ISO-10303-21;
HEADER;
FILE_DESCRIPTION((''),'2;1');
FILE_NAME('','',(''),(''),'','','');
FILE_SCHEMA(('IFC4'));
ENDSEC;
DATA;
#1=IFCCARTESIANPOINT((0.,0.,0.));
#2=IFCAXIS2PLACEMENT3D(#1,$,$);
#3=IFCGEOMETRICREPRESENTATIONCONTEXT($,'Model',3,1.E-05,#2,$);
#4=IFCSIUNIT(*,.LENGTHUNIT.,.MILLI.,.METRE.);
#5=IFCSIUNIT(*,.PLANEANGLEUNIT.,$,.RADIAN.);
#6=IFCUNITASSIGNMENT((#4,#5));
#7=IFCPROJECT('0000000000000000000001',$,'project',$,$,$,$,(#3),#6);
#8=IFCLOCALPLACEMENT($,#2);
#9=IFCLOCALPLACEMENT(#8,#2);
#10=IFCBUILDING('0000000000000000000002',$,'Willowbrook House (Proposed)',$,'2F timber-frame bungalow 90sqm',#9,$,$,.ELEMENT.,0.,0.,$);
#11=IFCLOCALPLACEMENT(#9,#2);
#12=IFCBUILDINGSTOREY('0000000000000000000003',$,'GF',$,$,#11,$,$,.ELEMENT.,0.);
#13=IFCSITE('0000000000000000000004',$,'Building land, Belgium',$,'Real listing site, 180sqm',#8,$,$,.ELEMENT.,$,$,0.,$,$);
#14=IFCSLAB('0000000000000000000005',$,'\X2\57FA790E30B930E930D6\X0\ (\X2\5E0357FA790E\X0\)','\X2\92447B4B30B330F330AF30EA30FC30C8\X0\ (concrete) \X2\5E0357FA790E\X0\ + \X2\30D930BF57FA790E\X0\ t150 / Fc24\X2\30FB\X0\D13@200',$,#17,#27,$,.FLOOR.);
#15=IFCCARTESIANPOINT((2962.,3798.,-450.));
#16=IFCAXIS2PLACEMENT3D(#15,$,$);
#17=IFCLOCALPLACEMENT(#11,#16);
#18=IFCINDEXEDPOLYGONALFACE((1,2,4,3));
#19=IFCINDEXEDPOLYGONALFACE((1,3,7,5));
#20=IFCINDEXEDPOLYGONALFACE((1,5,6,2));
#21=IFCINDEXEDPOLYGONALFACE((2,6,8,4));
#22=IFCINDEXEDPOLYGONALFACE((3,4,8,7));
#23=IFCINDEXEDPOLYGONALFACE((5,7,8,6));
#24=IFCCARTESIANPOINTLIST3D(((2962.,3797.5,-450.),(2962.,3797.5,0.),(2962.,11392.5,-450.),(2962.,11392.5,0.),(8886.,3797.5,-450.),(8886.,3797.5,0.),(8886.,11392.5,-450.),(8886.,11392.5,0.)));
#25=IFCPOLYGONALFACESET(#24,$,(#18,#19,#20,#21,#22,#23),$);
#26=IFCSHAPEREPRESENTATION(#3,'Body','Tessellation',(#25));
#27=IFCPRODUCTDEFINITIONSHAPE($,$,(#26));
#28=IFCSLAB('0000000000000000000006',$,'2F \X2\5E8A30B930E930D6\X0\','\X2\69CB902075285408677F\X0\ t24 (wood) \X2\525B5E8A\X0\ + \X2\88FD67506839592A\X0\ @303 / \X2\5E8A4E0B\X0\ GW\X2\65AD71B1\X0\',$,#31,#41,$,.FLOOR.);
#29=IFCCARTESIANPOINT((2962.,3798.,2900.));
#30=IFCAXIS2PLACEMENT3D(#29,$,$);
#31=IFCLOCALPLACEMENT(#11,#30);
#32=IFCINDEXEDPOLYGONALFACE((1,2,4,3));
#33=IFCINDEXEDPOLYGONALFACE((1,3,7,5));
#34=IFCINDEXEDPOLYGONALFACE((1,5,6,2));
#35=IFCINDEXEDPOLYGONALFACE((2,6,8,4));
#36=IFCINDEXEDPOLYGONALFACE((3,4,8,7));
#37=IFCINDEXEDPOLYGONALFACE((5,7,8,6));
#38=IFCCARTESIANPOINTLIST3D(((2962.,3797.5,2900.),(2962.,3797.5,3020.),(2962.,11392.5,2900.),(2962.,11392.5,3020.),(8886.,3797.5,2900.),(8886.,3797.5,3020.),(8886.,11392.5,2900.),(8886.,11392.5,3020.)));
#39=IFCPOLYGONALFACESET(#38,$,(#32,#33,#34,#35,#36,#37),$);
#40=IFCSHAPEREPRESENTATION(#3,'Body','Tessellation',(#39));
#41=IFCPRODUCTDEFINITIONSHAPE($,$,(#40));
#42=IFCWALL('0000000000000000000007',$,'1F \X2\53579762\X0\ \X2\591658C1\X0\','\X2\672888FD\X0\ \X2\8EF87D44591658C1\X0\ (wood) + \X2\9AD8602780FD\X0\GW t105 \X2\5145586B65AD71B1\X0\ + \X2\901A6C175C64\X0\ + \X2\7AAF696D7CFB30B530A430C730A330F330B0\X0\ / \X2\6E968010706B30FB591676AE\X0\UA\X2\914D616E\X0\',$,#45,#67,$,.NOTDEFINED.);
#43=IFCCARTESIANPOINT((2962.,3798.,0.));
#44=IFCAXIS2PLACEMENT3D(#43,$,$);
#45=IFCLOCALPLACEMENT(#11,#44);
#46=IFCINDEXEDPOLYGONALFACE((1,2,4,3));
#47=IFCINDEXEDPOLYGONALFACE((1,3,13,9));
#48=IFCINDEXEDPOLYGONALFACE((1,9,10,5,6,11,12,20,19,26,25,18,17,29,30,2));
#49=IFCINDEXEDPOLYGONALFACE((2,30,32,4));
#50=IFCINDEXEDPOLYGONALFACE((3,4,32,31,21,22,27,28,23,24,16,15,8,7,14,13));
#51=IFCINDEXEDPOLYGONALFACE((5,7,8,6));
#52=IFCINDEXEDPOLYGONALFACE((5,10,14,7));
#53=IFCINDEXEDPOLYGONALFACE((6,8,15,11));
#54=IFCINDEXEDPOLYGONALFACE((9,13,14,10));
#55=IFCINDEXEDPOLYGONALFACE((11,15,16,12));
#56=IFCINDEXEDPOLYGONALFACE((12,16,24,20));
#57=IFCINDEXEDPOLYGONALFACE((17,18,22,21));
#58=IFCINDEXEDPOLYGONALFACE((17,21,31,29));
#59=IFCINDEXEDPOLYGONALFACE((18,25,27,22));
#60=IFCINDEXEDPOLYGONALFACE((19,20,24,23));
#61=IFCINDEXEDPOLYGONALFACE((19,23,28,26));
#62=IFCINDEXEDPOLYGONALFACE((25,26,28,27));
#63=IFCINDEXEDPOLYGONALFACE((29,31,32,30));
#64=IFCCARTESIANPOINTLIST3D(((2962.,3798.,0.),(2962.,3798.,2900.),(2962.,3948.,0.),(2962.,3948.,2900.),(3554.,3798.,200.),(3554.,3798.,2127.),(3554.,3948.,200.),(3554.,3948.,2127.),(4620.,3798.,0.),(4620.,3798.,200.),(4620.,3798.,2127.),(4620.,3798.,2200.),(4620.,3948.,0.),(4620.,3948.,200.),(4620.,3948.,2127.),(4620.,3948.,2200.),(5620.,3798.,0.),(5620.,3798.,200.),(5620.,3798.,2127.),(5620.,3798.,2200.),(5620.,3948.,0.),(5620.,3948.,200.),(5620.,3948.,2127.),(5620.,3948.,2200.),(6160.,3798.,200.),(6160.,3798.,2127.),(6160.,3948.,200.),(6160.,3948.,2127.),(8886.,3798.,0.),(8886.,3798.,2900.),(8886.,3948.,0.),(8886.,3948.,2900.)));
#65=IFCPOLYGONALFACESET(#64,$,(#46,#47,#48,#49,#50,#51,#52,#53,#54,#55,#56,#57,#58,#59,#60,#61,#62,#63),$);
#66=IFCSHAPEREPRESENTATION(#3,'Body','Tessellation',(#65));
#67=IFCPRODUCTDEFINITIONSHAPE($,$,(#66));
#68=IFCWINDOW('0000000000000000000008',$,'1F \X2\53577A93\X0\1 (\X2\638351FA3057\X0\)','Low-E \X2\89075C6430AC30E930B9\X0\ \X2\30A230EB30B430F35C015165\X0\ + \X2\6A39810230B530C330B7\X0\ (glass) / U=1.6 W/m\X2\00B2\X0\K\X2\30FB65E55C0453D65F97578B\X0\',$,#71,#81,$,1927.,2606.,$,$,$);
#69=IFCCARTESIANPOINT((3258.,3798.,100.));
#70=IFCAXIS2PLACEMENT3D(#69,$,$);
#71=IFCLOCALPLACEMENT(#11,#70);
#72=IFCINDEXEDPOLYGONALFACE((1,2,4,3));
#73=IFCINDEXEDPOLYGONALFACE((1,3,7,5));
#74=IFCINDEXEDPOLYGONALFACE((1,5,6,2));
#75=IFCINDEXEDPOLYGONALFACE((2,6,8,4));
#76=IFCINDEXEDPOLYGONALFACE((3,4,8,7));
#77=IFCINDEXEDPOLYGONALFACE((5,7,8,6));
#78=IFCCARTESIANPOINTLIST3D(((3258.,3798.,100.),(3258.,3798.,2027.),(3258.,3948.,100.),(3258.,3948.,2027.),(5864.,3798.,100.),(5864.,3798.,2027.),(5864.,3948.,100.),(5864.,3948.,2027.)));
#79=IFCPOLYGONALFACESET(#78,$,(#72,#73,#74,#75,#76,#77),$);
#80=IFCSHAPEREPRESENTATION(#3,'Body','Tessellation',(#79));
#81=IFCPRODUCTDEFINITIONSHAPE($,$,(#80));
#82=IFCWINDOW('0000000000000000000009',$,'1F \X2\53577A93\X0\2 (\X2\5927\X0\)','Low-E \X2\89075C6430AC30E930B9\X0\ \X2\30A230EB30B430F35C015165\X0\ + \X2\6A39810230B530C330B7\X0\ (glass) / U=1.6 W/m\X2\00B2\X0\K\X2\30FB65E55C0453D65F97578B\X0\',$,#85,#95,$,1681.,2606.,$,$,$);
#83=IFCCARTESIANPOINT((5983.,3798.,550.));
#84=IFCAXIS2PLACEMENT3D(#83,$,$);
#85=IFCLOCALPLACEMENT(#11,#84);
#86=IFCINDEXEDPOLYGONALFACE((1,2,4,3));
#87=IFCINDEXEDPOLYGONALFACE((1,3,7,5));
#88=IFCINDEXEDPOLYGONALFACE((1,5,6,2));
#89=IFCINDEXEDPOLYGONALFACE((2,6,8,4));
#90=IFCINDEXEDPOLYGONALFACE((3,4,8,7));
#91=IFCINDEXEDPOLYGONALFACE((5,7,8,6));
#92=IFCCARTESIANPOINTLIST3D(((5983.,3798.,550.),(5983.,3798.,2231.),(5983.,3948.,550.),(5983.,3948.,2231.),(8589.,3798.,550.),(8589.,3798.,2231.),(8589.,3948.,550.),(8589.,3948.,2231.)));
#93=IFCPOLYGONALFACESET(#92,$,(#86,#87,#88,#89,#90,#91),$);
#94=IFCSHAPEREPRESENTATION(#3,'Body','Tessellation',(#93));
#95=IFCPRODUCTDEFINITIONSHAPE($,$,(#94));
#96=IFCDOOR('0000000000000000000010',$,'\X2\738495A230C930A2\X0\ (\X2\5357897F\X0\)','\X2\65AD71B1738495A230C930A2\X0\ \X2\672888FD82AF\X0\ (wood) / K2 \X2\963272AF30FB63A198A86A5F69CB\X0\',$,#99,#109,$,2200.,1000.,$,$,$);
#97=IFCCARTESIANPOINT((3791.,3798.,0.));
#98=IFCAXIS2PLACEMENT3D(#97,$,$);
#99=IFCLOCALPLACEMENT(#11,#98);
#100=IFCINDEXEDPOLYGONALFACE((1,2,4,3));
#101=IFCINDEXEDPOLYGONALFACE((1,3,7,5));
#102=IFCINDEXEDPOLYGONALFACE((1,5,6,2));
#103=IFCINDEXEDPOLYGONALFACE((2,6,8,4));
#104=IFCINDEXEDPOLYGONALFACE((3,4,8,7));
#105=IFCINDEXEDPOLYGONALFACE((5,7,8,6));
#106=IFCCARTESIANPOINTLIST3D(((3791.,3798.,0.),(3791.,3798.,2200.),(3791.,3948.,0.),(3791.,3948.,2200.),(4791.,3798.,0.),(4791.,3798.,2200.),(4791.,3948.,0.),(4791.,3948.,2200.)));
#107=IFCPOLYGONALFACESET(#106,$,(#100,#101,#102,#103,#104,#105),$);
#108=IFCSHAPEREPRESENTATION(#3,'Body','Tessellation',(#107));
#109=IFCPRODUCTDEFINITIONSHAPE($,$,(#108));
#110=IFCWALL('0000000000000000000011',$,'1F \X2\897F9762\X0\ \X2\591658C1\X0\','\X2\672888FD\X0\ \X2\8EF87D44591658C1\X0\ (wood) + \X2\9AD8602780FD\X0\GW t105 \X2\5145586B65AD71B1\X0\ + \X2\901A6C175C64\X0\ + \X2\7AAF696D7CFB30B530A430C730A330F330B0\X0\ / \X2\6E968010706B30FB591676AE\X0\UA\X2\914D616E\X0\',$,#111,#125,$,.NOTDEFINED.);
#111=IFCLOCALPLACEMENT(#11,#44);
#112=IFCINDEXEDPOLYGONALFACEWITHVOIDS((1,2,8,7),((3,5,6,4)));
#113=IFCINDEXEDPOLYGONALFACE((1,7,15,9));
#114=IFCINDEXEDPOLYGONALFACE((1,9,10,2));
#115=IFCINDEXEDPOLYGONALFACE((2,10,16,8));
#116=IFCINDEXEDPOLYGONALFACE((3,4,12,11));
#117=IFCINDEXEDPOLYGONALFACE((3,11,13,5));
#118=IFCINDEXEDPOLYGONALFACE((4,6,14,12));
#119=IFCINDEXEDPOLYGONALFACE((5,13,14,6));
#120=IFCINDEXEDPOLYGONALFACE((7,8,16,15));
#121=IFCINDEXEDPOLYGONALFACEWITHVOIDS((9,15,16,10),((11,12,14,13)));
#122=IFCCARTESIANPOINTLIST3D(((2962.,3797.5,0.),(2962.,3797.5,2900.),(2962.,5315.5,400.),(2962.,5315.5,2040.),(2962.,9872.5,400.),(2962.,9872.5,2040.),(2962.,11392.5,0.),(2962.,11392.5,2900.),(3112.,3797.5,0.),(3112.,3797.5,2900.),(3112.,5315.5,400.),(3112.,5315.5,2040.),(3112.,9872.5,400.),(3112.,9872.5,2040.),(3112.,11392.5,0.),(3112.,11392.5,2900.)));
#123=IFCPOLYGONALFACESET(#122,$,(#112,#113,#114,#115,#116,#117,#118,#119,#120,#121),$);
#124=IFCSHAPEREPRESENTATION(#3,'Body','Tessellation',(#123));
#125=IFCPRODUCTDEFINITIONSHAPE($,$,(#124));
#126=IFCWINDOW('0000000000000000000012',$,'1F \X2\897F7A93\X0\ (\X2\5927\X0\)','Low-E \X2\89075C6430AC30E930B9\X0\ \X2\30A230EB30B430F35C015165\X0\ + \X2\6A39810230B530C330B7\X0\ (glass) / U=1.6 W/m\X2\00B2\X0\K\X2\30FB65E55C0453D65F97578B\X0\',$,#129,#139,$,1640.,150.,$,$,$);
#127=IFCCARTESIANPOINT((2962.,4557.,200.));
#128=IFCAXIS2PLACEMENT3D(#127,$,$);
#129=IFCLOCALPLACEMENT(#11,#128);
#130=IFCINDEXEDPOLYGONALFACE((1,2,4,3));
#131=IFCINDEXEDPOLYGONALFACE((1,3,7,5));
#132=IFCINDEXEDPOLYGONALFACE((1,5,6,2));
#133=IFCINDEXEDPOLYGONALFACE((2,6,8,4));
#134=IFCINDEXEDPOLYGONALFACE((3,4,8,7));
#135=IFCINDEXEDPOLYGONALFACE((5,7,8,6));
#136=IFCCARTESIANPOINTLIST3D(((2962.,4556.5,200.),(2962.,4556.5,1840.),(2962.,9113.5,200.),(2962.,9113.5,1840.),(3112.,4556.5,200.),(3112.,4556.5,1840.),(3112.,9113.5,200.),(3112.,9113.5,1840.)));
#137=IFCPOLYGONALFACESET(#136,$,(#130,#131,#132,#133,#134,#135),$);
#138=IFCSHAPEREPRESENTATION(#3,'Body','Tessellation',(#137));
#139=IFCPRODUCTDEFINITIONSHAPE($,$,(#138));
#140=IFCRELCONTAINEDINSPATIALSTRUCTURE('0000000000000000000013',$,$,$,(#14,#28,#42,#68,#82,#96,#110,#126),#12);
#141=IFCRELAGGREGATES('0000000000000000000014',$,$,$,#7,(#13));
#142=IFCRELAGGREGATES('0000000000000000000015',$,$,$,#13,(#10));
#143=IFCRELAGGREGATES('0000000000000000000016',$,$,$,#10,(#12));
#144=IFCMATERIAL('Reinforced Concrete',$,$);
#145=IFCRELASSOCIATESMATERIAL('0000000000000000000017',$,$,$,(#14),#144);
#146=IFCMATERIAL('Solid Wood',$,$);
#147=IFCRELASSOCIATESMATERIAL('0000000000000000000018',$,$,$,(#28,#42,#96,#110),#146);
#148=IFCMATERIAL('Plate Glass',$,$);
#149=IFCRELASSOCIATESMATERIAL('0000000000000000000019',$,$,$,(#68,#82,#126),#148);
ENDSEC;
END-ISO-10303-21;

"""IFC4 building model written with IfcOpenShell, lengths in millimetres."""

from ifc_helpers import new_model, si_unit, frame, frame_2d, origin, place, context, project, spatial, rectangle, extrude, material, element, fill, save


model = new_model("IFC4")

# Units and contexts
model_context = context("Model", 3, precision=1e-05, world=origin())
ifc_project = project(units=[si_unit("LENGTHUNIT", "METRE", prefix="MILLI"), si_unit("PLANEANGLEUNIT", "RADIAN")], contexts=[model_context])

# Site, building, storey
site_placement = place(None, origin())
site = spatial("IfcSite", under=ifc_project, at=site_placement, Name="Building land, Belgium", ObjectType="Real listing site, 180sqm", CompositionType="ELEMENT", RefElevation=0.0)
building_placement = place(site_placement, origin())
building = spatial("IfcBuilding", under=site, at=building_placement, Name="Willowbrook House (Proposed)", ObjectType="2F timber-frame bungalow 90sqm", CompositionType="ELEMENT", ElevationOfRefHeight=0.0, ElevationOfTerrain=0.0)
storey_placement = place(building_placement, origin())
storey = spatial("IfcBuildingStorey", under=building, at=storey_placement, Name="GF", CompositionType="ELEMENT", Elevation=0.0)

# Slabs
ifc_material_1 = material(Name="Reinforced Concrete")
slab_1_placement = place(storey_placement, frame((2962.0, 3798.0, -450.0)))
element("IfcSlab", 1, at=slab_1_placement, inside=storey, material=ifc_material_1, Name="基礎スラブ (布基礎)", Description="鉄筋コンクリート (concrete) 布基礎 + ベタ基礎 t150 / Fc24・D13@200", PredefinedType="FLOOR", context=model_context, shape_type="SweptSolid", body=[
    extrude(rectangle(XDim=5924.0, YDim=7595.0, at=frame_2d((2962.0, 3797.0))), frame((2962.0, 3798.0, -450.0)), (0.0, 0.0, 1.0), 450.0),
])
ifc_material_2 = material(Name="Solid Wood")
slab_2_placement = place(storey_placement, frame((2962.0, 3798.0, 2900.0)))
element("IfcSlab", 2, at=slab_2_placement, inside=storey, material=ifc_material_2, Name="2F 床スラブ", Description="構造用合板 t24 (wood) 剛床 + 製材根太 @303 / 床下 GW断熱", PredefinedType="FLOOR", context=model_context, shape_type="SweptSolid", body=[
    extrude(rectangle(XDim=5924.0, YDim=7595.0, at=frame_2d((2962.0, 3797.0))), frame((2962.0, 3798.0, 2900.0)), (0.0, 0.0, 1.0), 120.0),
])

# Wall, openings, windows, door
wall_1_placement = place(storey_placement, frame((2962.0, 3798.0, 0.0)))
wall_1 = element("IfcWall", 3, at=wall_1_placement, inside=storey, material=ifc_material_2, Name="1F 南面 外壁", Description="木製 軸組外壁 (wood) + 高性能GW t105 充填断熱 + 通気層 + 窯業系サイディング / 準耐火・外皮UA配慮", PredefinedType="NOTDEFINED", context=model_context, shape_type="SweptSolid", body=[
    extrude(rectangle(XDim=5924.0, YDim=150.0, at=frame_2d((2962.0, 75.0))), frame((2962.0, 3798.0, 0.0)), (0.0, 0.0, 1.0), 2900.0),
])
opening_1_placement = place(storey_placement, frame((3258.0, 3798.0, 100.0)))
opening_1 = element("IfcOpeningElement", 4, at=opening_1_placement, cuts=wall_1, PredefinedType="NOTDEFINED", context=model_context, shape_type="SweptSolid", body=[
    extrude(rectangle(XDim=2606.0, YDim=150.0, at=frame_2d((1303.0, 75.0))), frame((3258.0, 3798.0, 100.0)), (0.0, 0.0, 1.0), 1927.0),
])
opening_2_placement = place(storey_placement, frame((5983.0, 3798.0, 550.0)))
opening_2 = element("IfcOpeningElement", 5, at=opening_2_placement, cuts=wall_1, PredefinedType="NOTDEFINED", context=model_context, shape_type="SweptSolid", body=[
    extrude(rectangle(XDim=2606.0, YDim=150.0, at=frame_2d((1303.0, 75.0))), frame((5983.0, 3798.0, 550.0)), (0.0, 0.0, 1.0), 1681.0),
])
opening_3_placement = place(storey_placement, frame((3791.0, 3798.0, 0.0)))
opening_3 = element("IfcOpeningElement", 6, at=opening_3_placement, cuts=wall_1, PredefinedType="NOTDEFINED", context=model_context, shape_type="SweptSolid", body=[
    extrude(rectangle(XDim=1000.0, YDim=150.0, at=frame_2d((500.0, 75.0))), frame((3791.0, 3798.0, 0.0)), (0.0, 0.0, 1.0), 2200.0),
])
ifc_material_3 = material(Name="Plate Glass")
window_1_placement = place(storey_placement, frame((3258.0, 3798.0, 100.0)))
window_1 = element("IfcWindow", 7, at=window_1_placement, inside=storey, material=ifc_material_3, Name="1F 南窓1 (掃出し)", Description="Low-E 複層ガラス アルゴン封入 + 樹脂サッシ (glass) / U=1.6 W/m²K・日射取得型", OverallHeight=1927.0, OverallWidth=2606.0, context=model_context, shape_type="SweptSolid", body=[
    extrude(rectangle(XDim=2606.0, YDim=150.0, at=frame_2d((1303.0, 75.0))), frame((3258.0, 3798.0, 100.0)), (0.0, 0.0, 1.0), 1927.0),
])
fill(opening_1, window_1)
window_2_placement = place(storey_placement, frame((5983.0, 3798.0, 550.0)))
window_2 = element("IfcWindow", 8, at=window_2_placement, inside=storey, material=ifc_material_3, Name="1F 南窓2 (大)", Description="Low-E 複層ガラス アルゴン封入 + 樹脂サッシ (glass) / U=1.6 W/m²K・日射取得型", OverallHeight=1681.0, OverallWidth=2606.0, context=model_context, shape_type="SweptSolid", body=[
    extrude(rectangle(XDim=2606.0, YDim=150.0, at=frame_2d((1303.0, 75.0))), frame((5983.0, 3798.0, 550.0)), (0.0, 0.0, 1.0), 1681.0),
])
fill(opening_2, window_2)
door_placement = place(storey_placement, frame((3791.0, 3798.0, 0.0)))
door = element("IfcDoor", 9, at=door_placement, inside=storey, material=ifc_material_2, Name="玄関ドア (南西)", Description="断熱玄関ドア 木製芯 (wood) / K2 防犯・採風機構", OverallHeight=2200.0, OverallWidth=1000.0, context=model_context, shape_type="SweptSolid", body=[
    extrude(rectangle(XDim=1000.0, YDim=150.0, at=frame_2d((500.0, 75.0))), frame((3791.0, 3798.0, 0.0)), (0.0, 0.0, 1.0), 2200.0),
])
fill(opening_3, door)

# Wall, opening, window
wall_2_placement = place(storey_placement, frame((2962.0, 3798.0, 0.0)))
wall_2 = element("IfcWall", 10, at=wall_2_placement, inside=storey, material=ifc_material_2, Name="1F 西面 外壁", Description="木製 軸組外壁 (wood) + 高性能GW t105 充填断熱 + 通気層 + 窯業系サイディング / 準耐火・外皮UA配慮", PredefinedType="NOTDEFINED", context=model_context, shape_type="SweptSolid", body=[
    extrude(rectangle(XDim=150.0, YDim=7595.0, at=frame_2d((75.0, 3797.0))), frame((2962.0, 3798.0, 0.0)), (0.0, 0.0, 1.0), 2900.0),
])
opening_4_placement = place(storey_placement, frame((2962.0, 4557.0, 200.0)))
opening_4 = element("IfcOpeningElement", 11, at=opening_4_placement, cuts=wall_2, PredefinedType="NOTDEFINED", context=model_context, shape_type="SweptSolid", body=[
    extrude(rectangle(XDim=150.0, YDim=4557.0, at=frame_2d((75.0, 2278.0))), frame((2962.0, 4557.0, 200.0)), (0.0, 0.0, 1.0), 1640.0),
])
window_3_placement = place(storey_placement, frame((2962.0, 4557.0, 200.0)))
window_3 = element("IfcWindow", 12, at=window_3_placement, inside=storey, material=ifc_material_3, Name="1F 西窓 (大)", Description="Low-E 複層ガラス アルゴン封入 + 樹脂サッシ (glass) / U=1.6 W/m²K・日射取得型", OverallHeight=1640.0, OverallWidth=150.0, context=model_context, shape_type="SweptSolid", body=[
    extrude(rectangle(XDim=150.0, YDim=4557.0, at=frame_2d((75.0, 2278.0))), frame((2962.0, 4557.0, 200.0)), (0.0, 0.0, 1.0), 1640.0),
])
fill(opening_4, window_3)

save(model, "model.ifc")
